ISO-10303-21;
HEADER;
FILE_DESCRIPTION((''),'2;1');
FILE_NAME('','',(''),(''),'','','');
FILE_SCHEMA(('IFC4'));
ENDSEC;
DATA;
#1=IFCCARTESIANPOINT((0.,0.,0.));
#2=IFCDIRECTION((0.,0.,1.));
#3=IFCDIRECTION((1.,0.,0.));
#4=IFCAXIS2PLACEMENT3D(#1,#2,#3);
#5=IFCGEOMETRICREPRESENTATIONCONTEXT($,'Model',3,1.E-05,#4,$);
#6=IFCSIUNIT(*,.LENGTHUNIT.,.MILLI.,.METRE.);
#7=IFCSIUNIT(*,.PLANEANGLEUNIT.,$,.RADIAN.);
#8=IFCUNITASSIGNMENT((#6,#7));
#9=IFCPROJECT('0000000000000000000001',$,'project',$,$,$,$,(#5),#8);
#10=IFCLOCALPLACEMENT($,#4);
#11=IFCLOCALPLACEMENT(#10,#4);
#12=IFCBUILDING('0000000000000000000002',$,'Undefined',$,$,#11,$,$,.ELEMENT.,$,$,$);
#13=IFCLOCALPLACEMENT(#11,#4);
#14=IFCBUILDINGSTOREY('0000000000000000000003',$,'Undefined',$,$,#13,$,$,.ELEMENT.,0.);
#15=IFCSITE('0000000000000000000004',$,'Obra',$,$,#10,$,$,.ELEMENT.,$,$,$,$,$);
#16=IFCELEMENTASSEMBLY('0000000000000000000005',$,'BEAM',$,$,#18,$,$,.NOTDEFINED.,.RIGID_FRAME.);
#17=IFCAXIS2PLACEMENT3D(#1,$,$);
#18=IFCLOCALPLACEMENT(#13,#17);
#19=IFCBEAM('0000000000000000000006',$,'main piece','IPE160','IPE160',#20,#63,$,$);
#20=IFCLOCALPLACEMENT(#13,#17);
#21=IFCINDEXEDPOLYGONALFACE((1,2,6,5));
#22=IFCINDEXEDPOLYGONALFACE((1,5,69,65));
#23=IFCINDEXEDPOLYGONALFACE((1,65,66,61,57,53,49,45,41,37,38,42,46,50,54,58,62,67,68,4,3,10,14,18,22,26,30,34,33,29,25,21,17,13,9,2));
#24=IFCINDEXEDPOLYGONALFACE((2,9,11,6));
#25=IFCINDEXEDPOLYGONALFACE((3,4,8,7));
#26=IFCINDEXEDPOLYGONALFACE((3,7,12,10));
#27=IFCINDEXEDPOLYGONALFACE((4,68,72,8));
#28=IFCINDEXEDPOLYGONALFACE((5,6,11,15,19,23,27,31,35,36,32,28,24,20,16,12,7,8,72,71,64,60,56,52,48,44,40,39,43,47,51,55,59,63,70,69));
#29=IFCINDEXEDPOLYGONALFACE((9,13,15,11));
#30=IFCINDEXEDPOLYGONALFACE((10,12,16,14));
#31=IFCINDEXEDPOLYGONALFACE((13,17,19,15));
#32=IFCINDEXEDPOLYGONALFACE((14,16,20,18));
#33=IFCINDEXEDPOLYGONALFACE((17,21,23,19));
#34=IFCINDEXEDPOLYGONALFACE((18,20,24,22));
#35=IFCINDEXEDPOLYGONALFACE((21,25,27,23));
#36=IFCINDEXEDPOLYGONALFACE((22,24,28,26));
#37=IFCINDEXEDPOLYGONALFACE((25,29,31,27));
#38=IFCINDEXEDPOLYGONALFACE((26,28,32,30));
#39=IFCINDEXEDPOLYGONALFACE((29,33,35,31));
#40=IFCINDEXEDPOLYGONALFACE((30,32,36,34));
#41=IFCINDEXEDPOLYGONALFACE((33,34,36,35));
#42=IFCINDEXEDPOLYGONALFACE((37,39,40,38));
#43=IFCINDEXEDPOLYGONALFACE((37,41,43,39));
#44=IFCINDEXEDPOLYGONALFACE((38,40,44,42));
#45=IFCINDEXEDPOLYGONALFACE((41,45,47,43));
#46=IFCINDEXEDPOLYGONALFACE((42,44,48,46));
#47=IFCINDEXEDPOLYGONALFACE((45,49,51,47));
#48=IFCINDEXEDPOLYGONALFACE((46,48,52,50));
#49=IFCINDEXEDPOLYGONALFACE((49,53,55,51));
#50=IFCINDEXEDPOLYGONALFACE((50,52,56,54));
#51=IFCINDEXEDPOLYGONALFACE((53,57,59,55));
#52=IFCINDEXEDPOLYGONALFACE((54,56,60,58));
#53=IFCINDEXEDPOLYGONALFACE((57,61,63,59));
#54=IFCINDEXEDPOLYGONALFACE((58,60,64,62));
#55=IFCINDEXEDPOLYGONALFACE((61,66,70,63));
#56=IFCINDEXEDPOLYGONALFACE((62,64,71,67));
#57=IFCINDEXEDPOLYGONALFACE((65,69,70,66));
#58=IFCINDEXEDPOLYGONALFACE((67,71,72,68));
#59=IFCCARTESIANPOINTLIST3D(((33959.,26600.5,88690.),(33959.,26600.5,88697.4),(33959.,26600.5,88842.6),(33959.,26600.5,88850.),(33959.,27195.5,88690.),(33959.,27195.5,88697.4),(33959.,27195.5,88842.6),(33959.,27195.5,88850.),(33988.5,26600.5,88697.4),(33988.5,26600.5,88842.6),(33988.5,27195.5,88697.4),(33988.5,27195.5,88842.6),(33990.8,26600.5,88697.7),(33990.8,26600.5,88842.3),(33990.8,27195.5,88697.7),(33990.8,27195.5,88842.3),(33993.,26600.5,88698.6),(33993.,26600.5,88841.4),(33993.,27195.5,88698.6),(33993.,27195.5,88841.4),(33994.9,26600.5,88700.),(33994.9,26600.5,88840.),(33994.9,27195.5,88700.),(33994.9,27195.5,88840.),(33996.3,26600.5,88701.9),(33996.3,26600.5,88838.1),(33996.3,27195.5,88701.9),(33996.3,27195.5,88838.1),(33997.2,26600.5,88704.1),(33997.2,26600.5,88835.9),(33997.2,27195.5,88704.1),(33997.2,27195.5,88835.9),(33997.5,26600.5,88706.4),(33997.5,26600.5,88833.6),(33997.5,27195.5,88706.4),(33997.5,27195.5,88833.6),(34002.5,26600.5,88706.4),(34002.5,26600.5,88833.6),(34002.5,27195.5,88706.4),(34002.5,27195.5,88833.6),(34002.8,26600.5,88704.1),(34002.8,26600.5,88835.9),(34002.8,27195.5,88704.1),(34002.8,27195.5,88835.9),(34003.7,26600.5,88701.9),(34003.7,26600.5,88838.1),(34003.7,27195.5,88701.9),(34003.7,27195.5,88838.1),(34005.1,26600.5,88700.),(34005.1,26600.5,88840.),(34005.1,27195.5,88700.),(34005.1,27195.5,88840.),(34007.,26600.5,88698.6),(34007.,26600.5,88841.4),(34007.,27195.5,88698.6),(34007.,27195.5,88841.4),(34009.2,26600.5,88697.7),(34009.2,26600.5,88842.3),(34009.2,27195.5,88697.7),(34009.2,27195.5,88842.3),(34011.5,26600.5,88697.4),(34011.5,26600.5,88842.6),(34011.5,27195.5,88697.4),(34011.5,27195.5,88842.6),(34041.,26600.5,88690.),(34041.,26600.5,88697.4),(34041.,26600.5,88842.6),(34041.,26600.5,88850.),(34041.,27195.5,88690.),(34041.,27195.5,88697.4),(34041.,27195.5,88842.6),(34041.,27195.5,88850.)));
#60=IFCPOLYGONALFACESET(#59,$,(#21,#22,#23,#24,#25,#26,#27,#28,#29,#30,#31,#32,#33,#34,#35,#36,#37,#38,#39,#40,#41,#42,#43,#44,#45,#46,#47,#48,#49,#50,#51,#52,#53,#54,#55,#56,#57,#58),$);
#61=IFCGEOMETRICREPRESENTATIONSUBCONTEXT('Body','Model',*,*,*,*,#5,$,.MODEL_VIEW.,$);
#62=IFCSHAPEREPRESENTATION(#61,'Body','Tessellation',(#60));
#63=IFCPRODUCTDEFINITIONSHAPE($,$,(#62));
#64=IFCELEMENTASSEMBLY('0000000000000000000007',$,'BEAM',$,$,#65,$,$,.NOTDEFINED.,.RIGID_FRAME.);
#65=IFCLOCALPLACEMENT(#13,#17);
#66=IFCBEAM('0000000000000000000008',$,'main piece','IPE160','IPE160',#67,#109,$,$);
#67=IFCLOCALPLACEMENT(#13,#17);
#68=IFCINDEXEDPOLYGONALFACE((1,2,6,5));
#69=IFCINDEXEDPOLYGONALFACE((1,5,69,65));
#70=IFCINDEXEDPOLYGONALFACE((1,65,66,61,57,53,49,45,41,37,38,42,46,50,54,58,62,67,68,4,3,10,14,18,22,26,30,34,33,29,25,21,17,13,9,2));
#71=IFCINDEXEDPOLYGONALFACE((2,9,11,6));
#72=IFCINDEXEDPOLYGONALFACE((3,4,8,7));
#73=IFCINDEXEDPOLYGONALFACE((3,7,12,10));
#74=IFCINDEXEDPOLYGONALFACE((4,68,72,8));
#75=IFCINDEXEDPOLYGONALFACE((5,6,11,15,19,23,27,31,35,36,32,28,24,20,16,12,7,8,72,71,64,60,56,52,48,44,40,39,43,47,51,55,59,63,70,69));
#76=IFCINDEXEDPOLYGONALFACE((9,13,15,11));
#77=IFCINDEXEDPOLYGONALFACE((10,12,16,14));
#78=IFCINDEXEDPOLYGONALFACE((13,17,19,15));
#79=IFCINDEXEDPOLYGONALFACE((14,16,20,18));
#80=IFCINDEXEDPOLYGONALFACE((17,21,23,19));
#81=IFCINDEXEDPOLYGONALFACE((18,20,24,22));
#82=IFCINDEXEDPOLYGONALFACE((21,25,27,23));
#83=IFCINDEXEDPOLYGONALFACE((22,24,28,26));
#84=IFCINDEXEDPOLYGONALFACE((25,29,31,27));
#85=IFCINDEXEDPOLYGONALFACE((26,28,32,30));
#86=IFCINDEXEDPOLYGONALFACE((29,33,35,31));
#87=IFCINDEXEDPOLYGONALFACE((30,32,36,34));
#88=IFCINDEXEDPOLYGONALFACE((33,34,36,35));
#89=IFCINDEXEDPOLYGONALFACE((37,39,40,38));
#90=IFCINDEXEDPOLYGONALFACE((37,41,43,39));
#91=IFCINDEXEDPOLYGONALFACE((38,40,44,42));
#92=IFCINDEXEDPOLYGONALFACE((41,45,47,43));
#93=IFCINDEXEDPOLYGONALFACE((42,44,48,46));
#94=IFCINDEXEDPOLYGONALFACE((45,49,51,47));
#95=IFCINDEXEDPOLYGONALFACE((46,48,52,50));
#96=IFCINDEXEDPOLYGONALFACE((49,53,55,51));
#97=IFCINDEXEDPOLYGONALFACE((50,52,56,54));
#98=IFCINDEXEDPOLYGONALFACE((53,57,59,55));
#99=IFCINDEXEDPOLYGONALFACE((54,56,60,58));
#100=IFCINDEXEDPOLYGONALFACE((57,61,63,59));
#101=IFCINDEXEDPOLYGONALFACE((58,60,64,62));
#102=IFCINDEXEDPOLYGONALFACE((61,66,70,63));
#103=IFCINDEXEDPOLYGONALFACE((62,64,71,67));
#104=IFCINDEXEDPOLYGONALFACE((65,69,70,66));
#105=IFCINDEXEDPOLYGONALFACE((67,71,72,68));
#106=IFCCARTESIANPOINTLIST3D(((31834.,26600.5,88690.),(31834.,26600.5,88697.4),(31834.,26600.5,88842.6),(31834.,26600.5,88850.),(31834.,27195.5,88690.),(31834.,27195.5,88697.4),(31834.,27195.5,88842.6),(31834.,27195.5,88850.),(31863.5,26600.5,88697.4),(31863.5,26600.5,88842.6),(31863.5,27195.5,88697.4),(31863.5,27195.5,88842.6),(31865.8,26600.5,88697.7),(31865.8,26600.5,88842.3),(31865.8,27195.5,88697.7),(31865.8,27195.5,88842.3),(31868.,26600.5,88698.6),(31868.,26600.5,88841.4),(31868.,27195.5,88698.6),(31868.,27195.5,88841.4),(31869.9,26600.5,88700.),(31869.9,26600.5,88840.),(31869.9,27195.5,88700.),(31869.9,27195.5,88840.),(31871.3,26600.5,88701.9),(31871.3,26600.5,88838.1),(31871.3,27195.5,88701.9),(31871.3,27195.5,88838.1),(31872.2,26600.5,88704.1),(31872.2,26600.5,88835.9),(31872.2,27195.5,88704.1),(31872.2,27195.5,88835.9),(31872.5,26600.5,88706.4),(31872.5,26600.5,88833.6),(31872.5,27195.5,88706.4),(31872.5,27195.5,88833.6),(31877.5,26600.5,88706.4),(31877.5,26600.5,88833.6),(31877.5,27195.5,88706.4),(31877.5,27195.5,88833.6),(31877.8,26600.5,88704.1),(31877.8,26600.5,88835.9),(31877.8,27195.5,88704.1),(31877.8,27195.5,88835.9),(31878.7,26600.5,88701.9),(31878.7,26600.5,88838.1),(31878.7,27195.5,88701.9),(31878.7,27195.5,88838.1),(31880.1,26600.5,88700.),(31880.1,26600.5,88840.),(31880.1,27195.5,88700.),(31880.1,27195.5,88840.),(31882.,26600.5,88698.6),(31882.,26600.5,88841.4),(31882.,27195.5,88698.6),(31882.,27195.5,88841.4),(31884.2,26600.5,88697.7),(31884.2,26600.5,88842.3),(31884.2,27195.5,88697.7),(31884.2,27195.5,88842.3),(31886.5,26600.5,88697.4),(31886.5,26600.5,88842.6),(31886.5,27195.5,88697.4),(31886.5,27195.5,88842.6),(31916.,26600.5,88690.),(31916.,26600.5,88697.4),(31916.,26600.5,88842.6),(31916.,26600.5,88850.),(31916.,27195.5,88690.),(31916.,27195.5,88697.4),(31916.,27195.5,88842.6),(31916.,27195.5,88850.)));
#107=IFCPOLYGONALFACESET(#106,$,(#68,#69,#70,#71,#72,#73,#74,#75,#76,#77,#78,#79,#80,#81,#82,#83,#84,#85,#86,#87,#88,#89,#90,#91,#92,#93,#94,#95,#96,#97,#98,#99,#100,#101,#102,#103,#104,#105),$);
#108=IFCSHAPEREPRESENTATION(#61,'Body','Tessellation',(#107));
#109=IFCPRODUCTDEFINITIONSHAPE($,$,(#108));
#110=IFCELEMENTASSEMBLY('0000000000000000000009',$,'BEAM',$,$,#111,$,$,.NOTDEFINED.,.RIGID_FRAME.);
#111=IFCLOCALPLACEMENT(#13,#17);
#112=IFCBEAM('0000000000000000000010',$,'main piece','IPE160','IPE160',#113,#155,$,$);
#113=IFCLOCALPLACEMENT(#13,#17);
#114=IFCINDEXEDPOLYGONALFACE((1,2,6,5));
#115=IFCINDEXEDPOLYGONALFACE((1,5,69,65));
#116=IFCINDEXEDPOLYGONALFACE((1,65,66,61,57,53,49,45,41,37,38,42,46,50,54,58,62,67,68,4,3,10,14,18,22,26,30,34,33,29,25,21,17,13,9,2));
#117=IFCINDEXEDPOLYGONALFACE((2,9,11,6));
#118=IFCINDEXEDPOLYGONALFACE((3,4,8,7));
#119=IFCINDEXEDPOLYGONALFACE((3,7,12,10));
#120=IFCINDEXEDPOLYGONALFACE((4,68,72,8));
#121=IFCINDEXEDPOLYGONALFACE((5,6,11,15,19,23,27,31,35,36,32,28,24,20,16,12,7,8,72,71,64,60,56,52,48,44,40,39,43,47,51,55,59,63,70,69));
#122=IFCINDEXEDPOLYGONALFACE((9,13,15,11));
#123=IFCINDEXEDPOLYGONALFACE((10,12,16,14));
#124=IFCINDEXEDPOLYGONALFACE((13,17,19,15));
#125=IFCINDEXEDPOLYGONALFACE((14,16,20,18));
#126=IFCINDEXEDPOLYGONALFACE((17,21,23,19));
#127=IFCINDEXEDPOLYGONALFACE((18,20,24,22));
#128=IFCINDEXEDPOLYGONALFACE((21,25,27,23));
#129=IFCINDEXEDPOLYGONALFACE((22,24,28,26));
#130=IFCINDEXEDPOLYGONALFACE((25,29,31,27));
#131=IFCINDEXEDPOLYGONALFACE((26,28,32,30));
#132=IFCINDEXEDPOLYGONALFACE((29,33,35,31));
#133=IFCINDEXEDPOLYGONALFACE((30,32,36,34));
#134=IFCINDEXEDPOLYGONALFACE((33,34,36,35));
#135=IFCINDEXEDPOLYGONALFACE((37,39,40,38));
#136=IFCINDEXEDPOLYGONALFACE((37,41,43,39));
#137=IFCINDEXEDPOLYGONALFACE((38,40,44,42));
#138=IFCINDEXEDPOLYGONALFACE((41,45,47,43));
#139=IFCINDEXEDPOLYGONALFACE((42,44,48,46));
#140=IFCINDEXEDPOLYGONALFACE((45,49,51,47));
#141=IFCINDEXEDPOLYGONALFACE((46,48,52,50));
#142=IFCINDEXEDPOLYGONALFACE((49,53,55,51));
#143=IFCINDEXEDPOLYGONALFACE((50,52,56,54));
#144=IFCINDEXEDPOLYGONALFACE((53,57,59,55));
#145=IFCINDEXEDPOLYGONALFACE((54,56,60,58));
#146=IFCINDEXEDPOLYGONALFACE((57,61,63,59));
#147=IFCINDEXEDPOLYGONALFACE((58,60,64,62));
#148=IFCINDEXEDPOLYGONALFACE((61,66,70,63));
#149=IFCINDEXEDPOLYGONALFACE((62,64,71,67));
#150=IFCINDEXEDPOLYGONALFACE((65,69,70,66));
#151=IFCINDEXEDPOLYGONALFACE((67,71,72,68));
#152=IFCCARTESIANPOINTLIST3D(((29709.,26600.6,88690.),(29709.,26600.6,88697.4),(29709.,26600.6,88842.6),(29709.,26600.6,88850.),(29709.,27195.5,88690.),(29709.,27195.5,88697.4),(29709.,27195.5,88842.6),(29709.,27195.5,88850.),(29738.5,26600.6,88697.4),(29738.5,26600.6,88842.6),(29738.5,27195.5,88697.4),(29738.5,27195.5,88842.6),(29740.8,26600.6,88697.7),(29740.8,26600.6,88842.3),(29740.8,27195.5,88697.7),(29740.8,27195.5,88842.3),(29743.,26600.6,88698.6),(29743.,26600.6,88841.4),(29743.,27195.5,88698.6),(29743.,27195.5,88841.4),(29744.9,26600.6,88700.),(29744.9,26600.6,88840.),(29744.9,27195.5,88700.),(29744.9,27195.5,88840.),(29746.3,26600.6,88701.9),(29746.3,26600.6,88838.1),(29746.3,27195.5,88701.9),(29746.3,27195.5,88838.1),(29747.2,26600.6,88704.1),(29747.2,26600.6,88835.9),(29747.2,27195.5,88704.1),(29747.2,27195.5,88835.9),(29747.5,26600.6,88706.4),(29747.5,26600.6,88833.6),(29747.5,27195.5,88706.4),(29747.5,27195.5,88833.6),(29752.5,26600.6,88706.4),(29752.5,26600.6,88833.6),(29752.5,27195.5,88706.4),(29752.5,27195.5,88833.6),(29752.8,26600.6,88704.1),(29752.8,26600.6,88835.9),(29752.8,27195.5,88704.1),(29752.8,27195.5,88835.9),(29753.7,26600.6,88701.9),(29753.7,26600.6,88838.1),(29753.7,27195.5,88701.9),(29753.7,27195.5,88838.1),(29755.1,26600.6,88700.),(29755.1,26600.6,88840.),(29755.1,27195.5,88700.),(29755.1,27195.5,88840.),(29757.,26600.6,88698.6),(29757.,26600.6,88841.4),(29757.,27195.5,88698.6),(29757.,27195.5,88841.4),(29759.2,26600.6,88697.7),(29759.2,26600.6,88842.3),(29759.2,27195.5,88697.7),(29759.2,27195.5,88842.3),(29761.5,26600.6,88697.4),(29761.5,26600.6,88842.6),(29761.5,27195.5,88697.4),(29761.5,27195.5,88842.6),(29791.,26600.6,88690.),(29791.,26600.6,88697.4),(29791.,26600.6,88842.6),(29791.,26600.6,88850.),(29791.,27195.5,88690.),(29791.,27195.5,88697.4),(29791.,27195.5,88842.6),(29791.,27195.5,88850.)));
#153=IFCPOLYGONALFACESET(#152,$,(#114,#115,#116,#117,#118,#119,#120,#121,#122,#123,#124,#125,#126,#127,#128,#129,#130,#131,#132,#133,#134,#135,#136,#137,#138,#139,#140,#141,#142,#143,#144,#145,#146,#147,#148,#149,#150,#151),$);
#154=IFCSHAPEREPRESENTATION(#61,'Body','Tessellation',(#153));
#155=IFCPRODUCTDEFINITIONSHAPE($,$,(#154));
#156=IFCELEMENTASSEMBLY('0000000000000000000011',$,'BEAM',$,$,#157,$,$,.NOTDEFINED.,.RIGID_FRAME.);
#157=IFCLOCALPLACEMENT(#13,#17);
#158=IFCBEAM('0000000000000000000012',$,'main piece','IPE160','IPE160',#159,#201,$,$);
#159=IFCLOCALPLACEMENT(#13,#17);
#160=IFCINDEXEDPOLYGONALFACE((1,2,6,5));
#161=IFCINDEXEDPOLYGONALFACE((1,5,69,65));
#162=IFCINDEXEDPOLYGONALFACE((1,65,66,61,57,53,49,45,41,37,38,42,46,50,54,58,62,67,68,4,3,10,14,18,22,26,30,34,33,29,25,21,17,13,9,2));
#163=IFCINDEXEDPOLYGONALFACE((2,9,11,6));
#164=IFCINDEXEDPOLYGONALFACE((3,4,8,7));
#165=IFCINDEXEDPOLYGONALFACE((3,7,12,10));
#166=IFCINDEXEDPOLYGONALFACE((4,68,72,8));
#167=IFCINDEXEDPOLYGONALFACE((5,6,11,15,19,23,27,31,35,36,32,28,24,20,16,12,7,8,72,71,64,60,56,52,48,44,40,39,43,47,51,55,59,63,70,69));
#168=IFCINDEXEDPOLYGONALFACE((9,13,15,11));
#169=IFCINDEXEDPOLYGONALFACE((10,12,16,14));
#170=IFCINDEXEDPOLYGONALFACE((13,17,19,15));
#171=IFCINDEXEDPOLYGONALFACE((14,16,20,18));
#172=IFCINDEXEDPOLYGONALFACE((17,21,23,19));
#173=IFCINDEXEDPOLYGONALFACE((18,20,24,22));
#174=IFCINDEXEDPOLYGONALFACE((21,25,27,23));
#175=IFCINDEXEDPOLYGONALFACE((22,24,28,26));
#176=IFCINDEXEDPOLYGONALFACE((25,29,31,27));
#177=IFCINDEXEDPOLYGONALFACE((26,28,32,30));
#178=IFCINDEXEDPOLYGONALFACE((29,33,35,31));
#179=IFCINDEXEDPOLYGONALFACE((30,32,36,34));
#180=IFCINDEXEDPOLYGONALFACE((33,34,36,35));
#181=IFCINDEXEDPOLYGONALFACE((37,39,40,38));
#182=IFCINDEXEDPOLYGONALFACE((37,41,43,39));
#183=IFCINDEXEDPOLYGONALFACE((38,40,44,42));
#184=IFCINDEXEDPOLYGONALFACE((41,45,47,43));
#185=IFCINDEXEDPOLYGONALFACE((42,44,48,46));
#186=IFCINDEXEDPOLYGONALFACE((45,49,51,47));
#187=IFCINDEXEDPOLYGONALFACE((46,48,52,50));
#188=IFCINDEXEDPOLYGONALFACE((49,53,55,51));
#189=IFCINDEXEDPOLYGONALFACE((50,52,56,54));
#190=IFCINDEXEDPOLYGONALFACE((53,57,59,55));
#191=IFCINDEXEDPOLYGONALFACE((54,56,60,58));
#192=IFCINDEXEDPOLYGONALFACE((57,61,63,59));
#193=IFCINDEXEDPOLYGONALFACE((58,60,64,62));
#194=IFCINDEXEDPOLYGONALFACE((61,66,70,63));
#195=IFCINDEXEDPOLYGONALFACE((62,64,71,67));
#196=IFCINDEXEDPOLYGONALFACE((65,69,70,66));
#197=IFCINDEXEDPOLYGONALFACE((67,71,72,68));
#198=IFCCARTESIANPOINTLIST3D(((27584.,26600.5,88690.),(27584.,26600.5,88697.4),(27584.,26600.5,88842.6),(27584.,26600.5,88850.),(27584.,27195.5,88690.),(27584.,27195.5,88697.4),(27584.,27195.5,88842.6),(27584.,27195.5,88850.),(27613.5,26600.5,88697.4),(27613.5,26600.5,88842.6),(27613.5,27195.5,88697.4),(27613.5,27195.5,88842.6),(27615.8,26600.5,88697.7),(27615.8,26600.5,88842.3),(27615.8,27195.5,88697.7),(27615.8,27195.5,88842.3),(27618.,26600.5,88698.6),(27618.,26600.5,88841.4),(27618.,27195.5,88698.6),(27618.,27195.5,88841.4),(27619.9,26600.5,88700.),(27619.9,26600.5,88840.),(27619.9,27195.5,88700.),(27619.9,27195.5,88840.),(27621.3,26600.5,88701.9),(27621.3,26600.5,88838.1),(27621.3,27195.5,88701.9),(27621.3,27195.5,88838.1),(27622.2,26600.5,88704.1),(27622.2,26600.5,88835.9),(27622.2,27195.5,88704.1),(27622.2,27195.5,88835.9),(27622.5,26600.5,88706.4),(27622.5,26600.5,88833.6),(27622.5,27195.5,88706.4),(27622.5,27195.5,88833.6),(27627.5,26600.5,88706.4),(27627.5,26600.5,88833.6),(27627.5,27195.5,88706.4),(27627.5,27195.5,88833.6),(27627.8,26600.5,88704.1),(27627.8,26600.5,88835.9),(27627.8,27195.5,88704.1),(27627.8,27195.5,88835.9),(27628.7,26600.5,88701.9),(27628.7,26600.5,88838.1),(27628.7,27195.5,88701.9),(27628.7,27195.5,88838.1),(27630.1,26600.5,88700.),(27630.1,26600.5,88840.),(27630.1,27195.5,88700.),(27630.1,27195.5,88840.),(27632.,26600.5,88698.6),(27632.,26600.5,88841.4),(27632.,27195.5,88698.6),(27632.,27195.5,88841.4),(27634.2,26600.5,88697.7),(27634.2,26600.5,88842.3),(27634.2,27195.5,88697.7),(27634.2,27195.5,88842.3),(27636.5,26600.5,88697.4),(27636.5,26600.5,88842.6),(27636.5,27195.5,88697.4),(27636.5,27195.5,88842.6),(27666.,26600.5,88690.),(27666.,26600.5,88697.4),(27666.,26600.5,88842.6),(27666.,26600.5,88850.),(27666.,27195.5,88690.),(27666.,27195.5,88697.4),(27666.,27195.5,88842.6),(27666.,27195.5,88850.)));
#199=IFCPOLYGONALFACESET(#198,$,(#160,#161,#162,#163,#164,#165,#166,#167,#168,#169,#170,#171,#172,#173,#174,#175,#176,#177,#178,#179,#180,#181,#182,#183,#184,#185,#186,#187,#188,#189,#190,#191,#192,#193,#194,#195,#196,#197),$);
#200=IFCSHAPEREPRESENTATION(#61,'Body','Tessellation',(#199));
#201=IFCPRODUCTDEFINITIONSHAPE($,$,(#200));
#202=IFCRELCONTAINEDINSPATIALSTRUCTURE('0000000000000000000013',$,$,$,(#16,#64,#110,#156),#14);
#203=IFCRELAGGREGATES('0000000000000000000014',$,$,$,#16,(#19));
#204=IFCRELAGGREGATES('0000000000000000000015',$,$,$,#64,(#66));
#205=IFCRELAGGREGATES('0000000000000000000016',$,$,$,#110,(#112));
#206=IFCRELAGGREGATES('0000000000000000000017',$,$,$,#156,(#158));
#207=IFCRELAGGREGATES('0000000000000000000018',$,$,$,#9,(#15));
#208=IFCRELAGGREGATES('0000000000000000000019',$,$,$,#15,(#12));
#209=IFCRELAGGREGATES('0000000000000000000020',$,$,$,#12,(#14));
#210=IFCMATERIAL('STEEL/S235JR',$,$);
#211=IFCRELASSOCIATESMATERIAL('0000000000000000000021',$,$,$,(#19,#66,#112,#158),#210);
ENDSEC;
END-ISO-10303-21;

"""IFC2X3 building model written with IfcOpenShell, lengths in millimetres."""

from ifc_helpers import new_model, si_unit, frame, origin_with_axes, origin_2d_with_axis, place, context, subcontext, project, spatial, i_section, extrude, material, element, aggregate, save


model = new_model("IFC2X3")

# Units and contexts
model_context = context("Model", 3, precision=1e-05, world=origin_with_axes())
body_context = subcontext(model_context, "Body", "Model", "MODEL_VIEW")
ifc_project = project(units=[si_unit("LENGTHUNIT", "METRE", prefix="MILLI"), si_unit("PLANEANGLEUNIT", "RADIAN")], contexts=[model_context])

# Site, building, storey
site_placement = place(None, origin_with_axes())
site = spatial("IfcSite", under=ifc_project, at=site_placement, Name="Obra", CompositionType="ELEMENT")
building_placement = place(site_placement, origin_with_axes())
building = spatial("IfcBuilding", under=site, at=building_placement, Name="Undefined", CompositionType="ELEMENT")
storey_placement = place(building_placement, origin_with_axes())
storey = spatial("IfcBuildingStorey", under=building, at=storey_placement, Name="Undefined", CompositionType="ELEMENT", Elevation=0.0)

# Element assemblies, beams
assembly_1_placement = place(storey_placement, origin_with_axes())
assembly_1 = element("IfcElementAssembly", 1, at=assembly_1_placement, inside=storey, Name="BEAM", AssemblyPlace="NOTDEFINED", PredefinedType="RIGID_FRAME")
ifc_material_1 = material(Name="STEEL/S235JR")
beam_1_placement = place(assembly_1_placement, frame((34000.0, 26600.5, 88770.0), z_axis=(0.0, 0.0, 1.0), x_axis=(0.0, 1.0, 0.0)))
beam_1 = element("IfcBeam", 2, at=beam_1_placement, material=ifc_material_1, Name="main piece", Description="IPE160", ObjectType="IPE160", context=body_context, shape_type="SweptSolid", body=[
    extrude(i_section(OverallWidth=82.0, OverallDepth=160.0, WebThickness=5.0, FlangeThickness=7.4, FilletRadius=9.0, at=origin_2d_with_axis()), frame((595.1, 0.0, 0.0), z_axis=(-1.0, 0.0, 0.0), x_axis=(0.0, -1.0, 0.0)), (0.0, 0.0, 1.0), 595.0),
])
aggregate(assembly_1, [beam_1])
assembly_2_placement = place(storey_placement, origin_with_axes())
assembly_2 = element("IfcElementAssembly", 3, at=assembly_2_placement, inside=storey, Name="BEAM", AssemblyPlace="NOTDEFINED", PredefinedType="RIGID_FRAME")
beam_2_placement = place(assembly_2_placement, frame((31875.0, 26600.5, 88770.0), z_axis=(0.0, 0.0, 1.0), x_axis=(0.0, 1.0, 0.0)))
beam_2 = element("IfcBeam", 4, at=beam_2_placement, material=ifc_material_1, Name="main piece", Description="IPE160", ObjectType="IPE160", context=body_context, shape_type="SweptSolid", body=[
    extrude(i_section(OverallWidth=82.0, OverallDepth=160.0, WebThickness=5.0, FlangeThickness=7.4, FilletRadius=9.0, at=origin_2d_with_axis()), frame((595.0, 0.0, 0.0), z_axis=(-1.0, 0.0, 0.0), x_axis=(0.0, -1.0, 0.0)), (0.0, 0.0, 1.0), 595.0),
])
aggregate(assembly_2, [beam_2])
assembly_3_placement = place(storey_placement, origin_with_axes())
assembly_3 = element("IfcElementAssembly", 5, at=assembly_3_placement, inside=storey, Name="BEAM", AssemblyPlace="NOTDEFINED", PredefinedType="RIGID_FRAME")
beam_3_placement = place(assembly_3_placement, frame((29750.0, 26600.6, 88770.0), z_axis=(0.0, 0.0, 1.0), x_axis=(0.0, 1.0, 0.0)))
beam_3 = element("IfcBeam", 6, at=beam_3_placement, material=ifc_material_1, Name="main piece", Description="IPE160", ObjectType="IPE160", context=body_context, shape_type="SweptSolid", body=[
    extrude(i_section(OverallWidth=82.0, OverallDepth=160.0, WebThickness=5.0, FlangeThickness=7.4, FilletRadius=9.0, at=origin_2d_with_axis()), frame((594.9, 0.0, 0.0), z_axis=(-1.0, 0.0, 0.0), x_axis=(0.0, -1.0, 0.0)), (0.0, 0.0, 1.0), 594.9),
])
aggregate(assembly_3, [beam_3])
assembly_4_placement = place(storey_placement, origin_with_axes())
assembly_4 = element("IfcElementAssembly", 7, at=assembly_4_placement, inside=storey, Name="BEAM", AssemblyPlace="NOTDEFINED", PredefinedType="RIGID_FRAME")
beam_4_placement = place(assembly_4_placement, frame((27625.0, 26600.5, 88770.0), z_axis=(0.0, 0.0, 1.0), x_axis=(0.0, 1.0, 0.0)))
beam_4 = element("IfcBeam", 8, at=beam_4_placement, material=ifc_material_1, Name="main piece", Description="IPE160", ObjectType="IPE160", context=body_context, shape_type="SweptSolid", body=[
    extrude(i_section(OverallWidth=82.0, OverallDepth=160.0, WebThickness=5.0, FlangeThickness=7.4, FilletRadius=9.0, at=origin_2d_with_axis()), frame((595.0, 0.0, 0.0), z_axis=(-1.0, 0.0, 0.0), x_axis=(0.0, -1.0, 0.0)), (0.0, 0.0, 1.0), 595.0),
])
aggregate(assembly_4, [beam_4])

save(model, "model.ifc")
